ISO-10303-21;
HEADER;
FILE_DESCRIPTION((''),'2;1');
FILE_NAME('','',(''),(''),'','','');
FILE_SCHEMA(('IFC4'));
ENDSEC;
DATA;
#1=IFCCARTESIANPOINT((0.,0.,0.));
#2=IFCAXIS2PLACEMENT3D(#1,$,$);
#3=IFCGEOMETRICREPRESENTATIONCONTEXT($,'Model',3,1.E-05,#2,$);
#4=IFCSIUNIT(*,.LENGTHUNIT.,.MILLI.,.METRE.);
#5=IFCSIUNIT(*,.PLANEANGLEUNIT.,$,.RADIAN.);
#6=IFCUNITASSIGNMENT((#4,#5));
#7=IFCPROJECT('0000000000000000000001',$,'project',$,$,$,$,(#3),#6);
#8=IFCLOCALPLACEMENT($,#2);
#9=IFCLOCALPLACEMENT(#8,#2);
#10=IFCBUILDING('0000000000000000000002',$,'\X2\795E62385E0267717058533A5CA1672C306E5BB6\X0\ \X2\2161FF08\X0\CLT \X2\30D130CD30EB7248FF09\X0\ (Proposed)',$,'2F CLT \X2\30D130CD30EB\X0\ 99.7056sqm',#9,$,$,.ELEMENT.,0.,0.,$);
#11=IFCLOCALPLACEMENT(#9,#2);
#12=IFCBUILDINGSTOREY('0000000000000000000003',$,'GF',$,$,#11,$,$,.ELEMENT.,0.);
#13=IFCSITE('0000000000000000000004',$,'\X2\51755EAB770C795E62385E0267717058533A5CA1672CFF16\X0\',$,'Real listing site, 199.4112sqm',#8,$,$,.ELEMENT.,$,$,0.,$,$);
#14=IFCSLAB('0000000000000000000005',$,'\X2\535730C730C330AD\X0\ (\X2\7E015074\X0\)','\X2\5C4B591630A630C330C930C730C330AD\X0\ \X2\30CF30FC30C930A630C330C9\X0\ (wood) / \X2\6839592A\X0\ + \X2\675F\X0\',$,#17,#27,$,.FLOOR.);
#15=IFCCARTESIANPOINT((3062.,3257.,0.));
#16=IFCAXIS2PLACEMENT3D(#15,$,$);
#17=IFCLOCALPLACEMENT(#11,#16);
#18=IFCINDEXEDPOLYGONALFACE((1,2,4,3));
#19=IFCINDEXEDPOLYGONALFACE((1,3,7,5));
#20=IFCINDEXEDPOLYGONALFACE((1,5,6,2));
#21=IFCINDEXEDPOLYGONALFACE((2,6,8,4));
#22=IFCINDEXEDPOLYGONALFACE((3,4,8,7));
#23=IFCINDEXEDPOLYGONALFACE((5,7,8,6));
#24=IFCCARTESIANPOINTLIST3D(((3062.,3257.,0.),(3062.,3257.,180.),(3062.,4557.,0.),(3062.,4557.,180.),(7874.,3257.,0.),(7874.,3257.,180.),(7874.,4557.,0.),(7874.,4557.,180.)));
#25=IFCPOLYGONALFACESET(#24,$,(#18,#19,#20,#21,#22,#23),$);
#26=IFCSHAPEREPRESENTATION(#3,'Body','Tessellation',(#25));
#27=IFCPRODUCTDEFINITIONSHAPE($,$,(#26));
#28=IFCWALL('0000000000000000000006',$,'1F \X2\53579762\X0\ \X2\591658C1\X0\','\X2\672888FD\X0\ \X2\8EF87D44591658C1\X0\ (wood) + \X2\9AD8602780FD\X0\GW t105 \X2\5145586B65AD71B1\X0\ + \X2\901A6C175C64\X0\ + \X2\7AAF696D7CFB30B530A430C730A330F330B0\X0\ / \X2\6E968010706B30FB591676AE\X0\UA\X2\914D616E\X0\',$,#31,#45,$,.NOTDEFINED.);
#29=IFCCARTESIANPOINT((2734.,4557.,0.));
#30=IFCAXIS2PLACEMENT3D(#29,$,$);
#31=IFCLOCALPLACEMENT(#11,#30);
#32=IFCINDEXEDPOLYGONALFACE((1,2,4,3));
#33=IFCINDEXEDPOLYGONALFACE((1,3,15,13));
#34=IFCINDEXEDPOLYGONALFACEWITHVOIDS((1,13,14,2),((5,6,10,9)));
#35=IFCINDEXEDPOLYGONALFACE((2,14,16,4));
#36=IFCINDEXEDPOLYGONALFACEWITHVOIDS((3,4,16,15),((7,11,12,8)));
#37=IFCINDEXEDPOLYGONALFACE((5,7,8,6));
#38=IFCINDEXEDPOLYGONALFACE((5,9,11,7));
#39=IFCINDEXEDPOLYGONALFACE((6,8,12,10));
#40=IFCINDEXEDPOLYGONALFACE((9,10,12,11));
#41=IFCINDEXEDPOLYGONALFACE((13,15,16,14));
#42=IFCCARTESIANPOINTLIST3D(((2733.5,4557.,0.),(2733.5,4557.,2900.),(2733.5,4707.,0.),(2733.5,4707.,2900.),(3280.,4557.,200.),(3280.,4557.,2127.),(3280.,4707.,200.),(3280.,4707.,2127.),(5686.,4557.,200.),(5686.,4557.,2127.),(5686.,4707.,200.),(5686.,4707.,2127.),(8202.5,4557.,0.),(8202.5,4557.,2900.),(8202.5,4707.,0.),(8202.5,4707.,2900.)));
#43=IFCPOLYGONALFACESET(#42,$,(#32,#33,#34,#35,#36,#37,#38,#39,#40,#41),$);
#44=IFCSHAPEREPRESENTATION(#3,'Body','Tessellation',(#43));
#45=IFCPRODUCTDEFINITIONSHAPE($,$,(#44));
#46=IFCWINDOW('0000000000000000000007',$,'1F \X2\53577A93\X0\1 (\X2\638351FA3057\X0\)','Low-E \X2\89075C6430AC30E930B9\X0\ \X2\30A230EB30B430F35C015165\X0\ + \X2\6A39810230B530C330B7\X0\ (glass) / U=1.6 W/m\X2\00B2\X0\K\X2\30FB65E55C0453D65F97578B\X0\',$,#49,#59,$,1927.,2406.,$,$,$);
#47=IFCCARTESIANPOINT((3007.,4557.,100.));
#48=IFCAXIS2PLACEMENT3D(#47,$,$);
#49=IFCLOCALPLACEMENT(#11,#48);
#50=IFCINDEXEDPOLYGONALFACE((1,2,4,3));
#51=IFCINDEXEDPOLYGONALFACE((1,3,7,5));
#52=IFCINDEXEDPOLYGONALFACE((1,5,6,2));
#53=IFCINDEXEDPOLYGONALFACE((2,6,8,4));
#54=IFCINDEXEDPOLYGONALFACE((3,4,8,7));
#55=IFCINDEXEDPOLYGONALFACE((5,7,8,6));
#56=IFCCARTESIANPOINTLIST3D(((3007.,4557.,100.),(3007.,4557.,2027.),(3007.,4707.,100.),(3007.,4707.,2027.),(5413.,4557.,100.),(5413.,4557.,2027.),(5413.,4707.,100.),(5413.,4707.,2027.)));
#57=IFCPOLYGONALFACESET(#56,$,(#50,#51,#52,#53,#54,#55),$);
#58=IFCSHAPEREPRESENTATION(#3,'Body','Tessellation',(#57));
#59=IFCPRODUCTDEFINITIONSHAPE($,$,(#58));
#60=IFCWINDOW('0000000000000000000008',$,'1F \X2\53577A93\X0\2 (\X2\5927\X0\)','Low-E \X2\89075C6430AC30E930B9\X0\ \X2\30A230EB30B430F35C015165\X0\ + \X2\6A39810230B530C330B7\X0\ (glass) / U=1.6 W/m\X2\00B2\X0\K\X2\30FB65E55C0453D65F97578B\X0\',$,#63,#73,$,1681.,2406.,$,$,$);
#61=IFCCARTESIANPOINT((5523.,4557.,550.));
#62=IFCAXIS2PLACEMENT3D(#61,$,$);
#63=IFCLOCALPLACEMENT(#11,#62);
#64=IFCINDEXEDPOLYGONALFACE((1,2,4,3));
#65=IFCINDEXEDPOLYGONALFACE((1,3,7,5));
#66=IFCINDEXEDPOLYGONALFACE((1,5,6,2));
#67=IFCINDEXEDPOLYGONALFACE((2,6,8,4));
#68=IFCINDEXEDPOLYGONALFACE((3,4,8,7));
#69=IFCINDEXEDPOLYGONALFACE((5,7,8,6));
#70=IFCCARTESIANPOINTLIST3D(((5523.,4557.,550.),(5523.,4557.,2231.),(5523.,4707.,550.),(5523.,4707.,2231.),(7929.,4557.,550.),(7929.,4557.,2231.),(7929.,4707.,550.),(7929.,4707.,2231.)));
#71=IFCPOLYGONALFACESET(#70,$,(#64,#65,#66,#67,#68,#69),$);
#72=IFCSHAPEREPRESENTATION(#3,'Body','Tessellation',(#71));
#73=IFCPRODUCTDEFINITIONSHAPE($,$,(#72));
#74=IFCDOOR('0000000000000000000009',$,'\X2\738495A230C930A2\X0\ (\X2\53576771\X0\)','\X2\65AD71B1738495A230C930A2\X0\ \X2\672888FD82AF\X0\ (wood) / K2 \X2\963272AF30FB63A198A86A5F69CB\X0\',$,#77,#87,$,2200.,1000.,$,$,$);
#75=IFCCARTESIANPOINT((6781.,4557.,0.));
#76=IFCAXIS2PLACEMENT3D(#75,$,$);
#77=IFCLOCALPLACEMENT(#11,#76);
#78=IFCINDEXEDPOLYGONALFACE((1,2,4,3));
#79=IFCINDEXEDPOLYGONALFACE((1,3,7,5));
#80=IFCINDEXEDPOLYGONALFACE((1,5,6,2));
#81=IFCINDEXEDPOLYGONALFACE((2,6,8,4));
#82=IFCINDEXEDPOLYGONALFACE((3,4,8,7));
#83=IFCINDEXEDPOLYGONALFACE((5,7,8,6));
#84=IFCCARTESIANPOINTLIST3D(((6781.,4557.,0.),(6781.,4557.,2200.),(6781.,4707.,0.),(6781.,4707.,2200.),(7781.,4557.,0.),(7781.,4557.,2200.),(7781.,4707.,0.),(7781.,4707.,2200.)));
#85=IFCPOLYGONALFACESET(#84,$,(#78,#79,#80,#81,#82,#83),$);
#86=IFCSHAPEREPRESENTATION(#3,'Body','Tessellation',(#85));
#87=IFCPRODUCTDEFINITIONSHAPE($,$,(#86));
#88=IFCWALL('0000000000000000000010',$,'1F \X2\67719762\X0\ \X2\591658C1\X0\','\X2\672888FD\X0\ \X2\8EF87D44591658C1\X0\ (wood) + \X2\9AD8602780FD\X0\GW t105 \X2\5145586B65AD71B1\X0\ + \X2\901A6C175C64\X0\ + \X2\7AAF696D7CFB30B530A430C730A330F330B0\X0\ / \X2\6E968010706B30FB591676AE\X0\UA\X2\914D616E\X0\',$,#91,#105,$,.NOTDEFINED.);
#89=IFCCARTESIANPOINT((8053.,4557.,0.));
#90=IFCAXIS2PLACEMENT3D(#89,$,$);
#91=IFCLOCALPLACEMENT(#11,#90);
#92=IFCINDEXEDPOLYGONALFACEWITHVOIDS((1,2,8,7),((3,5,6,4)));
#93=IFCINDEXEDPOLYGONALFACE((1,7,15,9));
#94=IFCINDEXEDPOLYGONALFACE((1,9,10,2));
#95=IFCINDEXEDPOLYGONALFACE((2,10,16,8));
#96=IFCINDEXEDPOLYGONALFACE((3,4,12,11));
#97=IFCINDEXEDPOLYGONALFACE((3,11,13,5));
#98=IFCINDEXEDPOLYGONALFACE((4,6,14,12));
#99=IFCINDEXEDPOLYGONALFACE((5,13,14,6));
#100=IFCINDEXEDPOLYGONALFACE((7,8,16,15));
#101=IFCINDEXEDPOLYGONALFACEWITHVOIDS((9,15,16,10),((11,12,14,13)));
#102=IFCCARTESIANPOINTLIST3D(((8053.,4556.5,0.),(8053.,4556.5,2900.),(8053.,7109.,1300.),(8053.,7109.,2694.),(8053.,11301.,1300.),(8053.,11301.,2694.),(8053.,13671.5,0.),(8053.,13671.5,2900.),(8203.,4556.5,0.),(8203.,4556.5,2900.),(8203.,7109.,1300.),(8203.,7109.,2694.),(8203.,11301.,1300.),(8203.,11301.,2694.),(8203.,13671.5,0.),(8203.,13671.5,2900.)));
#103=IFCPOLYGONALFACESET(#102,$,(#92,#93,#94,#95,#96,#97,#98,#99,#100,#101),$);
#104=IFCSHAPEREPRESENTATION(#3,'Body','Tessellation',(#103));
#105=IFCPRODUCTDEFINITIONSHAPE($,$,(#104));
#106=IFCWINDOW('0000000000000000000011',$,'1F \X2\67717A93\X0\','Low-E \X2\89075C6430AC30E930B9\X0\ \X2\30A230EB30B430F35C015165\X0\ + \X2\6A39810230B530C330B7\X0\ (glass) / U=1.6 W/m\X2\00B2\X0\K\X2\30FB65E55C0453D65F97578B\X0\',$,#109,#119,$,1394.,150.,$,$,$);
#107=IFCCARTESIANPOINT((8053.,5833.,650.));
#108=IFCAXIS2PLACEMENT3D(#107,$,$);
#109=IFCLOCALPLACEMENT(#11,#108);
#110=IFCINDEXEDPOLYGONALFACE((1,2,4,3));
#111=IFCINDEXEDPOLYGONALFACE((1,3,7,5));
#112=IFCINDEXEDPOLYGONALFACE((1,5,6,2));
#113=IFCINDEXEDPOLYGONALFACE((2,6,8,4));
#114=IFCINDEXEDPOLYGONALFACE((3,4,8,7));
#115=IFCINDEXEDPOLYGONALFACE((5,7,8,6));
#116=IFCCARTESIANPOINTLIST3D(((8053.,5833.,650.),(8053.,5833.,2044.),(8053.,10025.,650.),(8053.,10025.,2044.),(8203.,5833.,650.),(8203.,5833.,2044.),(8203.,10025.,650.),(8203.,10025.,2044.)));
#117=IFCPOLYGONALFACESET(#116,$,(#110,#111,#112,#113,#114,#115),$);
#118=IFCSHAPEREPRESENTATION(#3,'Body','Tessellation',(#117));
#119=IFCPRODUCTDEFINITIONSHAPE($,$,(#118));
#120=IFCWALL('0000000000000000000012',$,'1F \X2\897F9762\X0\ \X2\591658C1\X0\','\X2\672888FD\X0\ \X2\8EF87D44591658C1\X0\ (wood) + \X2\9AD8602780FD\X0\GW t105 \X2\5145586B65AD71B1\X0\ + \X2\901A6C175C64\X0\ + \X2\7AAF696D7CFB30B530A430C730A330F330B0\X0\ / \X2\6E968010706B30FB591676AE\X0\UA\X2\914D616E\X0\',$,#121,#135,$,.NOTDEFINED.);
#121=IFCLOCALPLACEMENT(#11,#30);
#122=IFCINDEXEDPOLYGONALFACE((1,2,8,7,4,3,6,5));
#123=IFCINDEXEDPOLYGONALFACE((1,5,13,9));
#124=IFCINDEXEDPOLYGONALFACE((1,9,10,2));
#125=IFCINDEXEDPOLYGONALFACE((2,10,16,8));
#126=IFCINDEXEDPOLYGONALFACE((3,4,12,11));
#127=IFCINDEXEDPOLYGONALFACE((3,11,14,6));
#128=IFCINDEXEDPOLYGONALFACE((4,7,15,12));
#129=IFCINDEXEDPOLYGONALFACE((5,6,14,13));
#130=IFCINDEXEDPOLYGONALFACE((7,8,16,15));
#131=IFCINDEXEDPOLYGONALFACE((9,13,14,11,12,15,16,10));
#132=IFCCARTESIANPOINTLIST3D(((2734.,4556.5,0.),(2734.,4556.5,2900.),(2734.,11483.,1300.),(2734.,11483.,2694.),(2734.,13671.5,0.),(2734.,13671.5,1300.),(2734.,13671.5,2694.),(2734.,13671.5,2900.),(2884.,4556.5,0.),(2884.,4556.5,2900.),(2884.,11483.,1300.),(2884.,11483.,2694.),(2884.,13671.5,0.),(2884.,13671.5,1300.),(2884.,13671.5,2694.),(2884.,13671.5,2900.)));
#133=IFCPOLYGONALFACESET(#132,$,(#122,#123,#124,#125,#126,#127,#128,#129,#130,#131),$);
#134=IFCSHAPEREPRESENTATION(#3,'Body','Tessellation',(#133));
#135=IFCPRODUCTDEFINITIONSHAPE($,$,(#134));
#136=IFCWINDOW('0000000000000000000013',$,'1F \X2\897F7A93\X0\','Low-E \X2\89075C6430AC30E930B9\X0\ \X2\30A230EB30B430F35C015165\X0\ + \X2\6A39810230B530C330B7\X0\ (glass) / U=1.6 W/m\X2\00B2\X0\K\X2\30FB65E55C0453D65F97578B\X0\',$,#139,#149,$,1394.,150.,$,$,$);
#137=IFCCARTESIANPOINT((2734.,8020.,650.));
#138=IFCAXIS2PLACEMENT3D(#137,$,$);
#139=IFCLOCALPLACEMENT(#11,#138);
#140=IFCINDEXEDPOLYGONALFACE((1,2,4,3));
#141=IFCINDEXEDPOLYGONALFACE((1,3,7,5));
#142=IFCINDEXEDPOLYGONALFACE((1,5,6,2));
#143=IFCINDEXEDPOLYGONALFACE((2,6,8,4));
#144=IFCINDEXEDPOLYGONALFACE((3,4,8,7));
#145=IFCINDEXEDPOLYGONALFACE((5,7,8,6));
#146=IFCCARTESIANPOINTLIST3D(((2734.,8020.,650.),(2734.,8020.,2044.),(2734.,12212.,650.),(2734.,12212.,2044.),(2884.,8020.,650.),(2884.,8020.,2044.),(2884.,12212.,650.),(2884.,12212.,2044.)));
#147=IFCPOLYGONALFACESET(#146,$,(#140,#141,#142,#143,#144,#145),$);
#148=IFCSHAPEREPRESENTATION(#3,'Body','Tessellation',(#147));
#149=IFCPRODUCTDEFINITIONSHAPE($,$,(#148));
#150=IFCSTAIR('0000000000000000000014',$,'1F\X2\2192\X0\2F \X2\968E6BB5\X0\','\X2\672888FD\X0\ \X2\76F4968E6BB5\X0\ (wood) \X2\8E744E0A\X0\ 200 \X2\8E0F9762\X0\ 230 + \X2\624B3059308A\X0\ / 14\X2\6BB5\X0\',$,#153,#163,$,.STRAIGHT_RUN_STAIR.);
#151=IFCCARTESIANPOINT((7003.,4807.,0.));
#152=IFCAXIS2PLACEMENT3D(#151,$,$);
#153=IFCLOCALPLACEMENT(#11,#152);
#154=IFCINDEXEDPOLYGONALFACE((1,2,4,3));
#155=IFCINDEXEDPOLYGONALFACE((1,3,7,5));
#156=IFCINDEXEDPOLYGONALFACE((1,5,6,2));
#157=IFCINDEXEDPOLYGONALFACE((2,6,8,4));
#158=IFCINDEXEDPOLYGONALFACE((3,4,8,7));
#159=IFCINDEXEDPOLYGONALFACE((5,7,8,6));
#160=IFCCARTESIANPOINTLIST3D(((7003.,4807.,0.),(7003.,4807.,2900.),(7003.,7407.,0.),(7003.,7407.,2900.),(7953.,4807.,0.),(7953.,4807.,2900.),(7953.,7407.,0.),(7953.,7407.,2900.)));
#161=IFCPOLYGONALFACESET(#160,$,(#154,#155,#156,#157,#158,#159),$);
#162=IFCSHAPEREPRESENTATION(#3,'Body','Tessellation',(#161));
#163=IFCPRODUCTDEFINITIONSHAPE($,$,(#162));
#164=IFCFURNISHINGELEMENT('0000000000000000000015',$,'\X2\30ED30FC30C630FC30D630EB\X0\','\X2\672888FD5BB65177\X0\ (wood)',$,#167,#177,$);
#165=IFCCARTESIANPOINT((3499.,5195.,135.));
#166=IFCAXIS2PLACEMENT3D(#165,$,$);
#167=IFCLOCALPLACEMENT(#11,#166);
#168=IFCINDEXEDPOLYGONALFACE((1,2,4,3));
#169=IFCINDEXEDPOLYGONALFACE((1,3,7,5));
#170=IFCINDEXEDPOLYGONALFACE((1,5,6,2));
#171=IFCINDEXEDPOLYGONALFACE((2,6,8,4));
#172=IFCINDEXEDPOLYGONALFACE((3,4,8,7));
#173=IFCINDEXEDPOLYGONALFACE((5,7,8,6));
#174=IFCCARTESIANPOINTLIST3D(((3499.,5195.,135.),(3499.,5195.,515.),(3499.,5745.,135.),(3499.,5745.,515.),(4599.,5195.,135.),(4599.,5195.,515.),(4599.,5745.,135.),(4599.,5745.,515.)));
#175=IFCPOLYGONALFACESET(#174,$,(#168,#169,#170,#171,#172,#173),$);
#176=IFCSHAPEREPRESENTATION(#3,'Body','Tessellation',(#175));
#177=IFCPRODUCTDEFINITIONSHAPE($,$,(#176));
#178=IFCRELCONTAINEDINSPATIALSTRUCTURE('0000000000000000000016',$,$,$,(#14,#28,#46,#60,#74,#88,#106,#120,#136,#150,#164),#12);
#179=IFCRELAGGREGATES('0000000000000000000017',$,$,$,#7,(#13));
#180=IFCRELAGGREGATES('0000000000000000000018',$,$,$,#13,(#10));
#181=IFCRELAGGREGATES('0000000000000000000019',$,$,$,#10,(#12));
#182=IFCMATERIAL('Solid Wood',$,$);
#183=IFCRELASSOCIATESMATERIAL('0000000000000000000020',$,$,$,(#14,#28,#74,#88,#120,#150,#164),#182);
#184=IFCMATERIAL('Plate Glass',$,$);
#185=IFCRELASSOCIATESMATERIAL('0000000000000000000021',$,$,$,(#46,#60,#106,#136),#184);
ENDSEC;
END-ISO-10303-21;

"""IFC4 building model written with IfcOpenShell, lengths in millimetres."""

from ifc_helpers import new_model, si_unit, frame, frame_2d, origin, place, context, project, spatial, rectangle, extrude, material, element, fill, save


model = new_model("IFC4")

# Units and contexts
model_context = context("Model", 3, precision=1e-05, world=origin())
ifc_project = project(units=[si_unit("LENGTHUNIT", "METRE", prefix="MILLI"), si_unit("PLANEANGLEUNIT", "RADIAN")], contexts=[model_context])

# Site, building, storey
site_placement = place(None, origin())
site = spatial("IfcSite", under=ifc_project, at=site_placement, Name="兵庫県神戸市東灘区岡本６", ObjectType="Real listing site, 199.4112sqm", CompositionType="ELEMENT", RefElevation=0.0)
building_placement = place(site_placement, origin())
building = spatial("IfcBuilding", under=site, at=building_placement, Name="神戸市東灘区岡本の家 Ⅱ（CLT パネル版） (Proposed)", ObjectType="2F CLT パネル 99.7056sqm", CompositionType="ELEMENT", ElevationOfRefHeight=0.0, ElevationOfTerrain=0.0)
storey_placement = place(building_placement, origin())
storey = spatial("IfcBuildingStorey", under=building, at=storey_placement, Name="GF", CompositionType="ELEMENT", Elevation=0.0)

# Slab
ifc_material_1 = material(Name="Solid Wood")
slab_1_placement = place(storey_placement, frame((3062.0, 3257.0, 0.0)))
element("IfcSlab", 1, at=slab_1_placement, inside=storey, material=ifc_material_1, Name="南デッキ (縁側)", Description="屋外ウッドデッキ ハードウッド (wood) / 根太 + 束", PredefinedType="FLOOR", context=model_context, shape_type="SweptSolid", body=[
    extrude(rectangle(XDim=4812.0, YDim=1300.0, at=frame_2d((2406.0, 650.0))), frame((3062.0, 3257.0, 0.0)), (0.0, 0.0, 1.0), 180.0),
])

# Wall, openings, windows, door
wall_1_placement = place(storey_placement, frame((2734.0, 4557.0, 0.0)))
wall_1 = element("IfcWall", 2, at=wall_1_placement, inside=storey, material=ifc_material_1, Name="1F 南面 外壁", Description="木製 軸組外壁 (wood) + 高性能GW t105 充填断熱 + 通気層 + 窯業系サイディング / 準耐火・外皮UA配慮", PredefinedType="NOTDEFINED", context=model_context, shape_type="SweptSolid", body=[
    extrude(rectangle(XDim=5469.0, YDim=150.0, at=frame_2d((2734.0, 75.0))), frame((2734.0, 4557.0, 0.0)), (0.0, 0.0, 1.0), 2900.0),
])
opening_1_placement = place(storey_placement, frame((3007.0, 4557.0, 100.0)))
opening_1 = element("IfcOpeningElement", 3, at=opening_1_placement, cuts=wall_1, PredefinedType="NOTDEFINED", context=model_context, shape_type="SweptSolid", body=[
    extrude(rectangle(XDim=2406.0, YDim=150.0, at=frame_2d((1203.0, 75.0))), frame((3007.0, 4557.0, 100.0)), (0.0, 0.0, 1.0), 1927.0),
])
opening_2_placement = place(storey_placement, frame((5523.0, 4557.0, 550.0)))
opening_2 = element("IfcOpeningElement", 4, at=opening_2_placement, cuts=wall_1, PredefinedType="NOTDEFINED", context=model_context, shape_type="SweptSolid", body=[
    extrude(rectangle(XDim=2406.0, YDim=150.0, at=frame_2d((1203.0, 75.0))), frame((5523.0, 4557.0, 550.0)), (0.0, 0.0, 1.0), 1681.0),
])
opening_3_placement = place(storey_placement, frame((6781.0, 4557.0, 0.0)))
opening_3 = element("IfcOpeningElement", 5, at=opening_3_placement, cuts=wall_1, PredefinedType="NOTDEFINED", context=model_context, shape_type="SweptSolid", body=[
    extrude(rectangle(XDim=1000.0, YDim=150.0, at=frame_2d((500.0, 75.0))), frame((6781.0, 4557.0, 0.0)), (0.0, 0.0, 1.0), 2200.0),
])
ifc_material_2 = material(Name="Plate Glass")
window_1_placement = place(storey_placement, frame((3007.0, 4557.0, 100.0)))
window_1 = element("IfcWindow", 6, at=window_1_placement, inside=storey, material=ifc_material_2, Name="1F 南窓1 (掃出し)", Description="Low-E 複層ガラス アルゴン封入 + 樹脂サッシ (glass) / U=1.6 W/m²K・日射取得型", OverallHeight=1927.0, OverallWidth=2406.0, context=model_context, shape_type="SweptSolid", body=[
    extrude(rectangle(XDim=2406.0, YDim=150.0, at=frame_2d((1203.0, 75.0))), frame((3007.0, 4557.0, 100.0)), (0.0, 0.0, 1.0), 1927.0),
])
fill(opening_1, window_1)
window_2_placement = place(storey_placement, frame((5523.0, 4557.0, 550.0)))
window_2 = element("IfcWindow", 7, at=window_2_placement, inside=storey, material=ifc_material_2, Name="1F 南窓2 (大)", Description="Low-E 複層ガラス アルゴン封入 + 樹脂サッシ (glass) / U=1.6 W/m²K・日射取得型", OverallHeight=1681.0, OverallWidth=2406.0, context=model_context, shape_type="SweptSolid", body=[
    extrude(rectangle(XDim=2406.0, YDim=150.0, at=frame_2d((1203.0, 75.0))), frame((5523.0, 4557.0, 550.0)), (0.0, 0.0, 1.0), 1681.0),
])
fill(opening_2, window_2)
door_placement = place(storey_placement, frame((6781.0, 4557.0, 0.0)))
door = element("IfcDoor", 8, at=door_placement, inside=storey, material=ifc_material_1, Name="玄関ドア (南東)", Description="断熱玄関ドア 木製芯 (wood) / K2 防犯・採風機構", OverallHeight=2200.0, OverallWidth=1000.0, context=model_context, shape_type="SweptSolid", body=[
    extrude(rectangle(XDim=1000.0, YDim=150.0, at=frame_2d((500.0, 75.0))), frame((6781.0, 4557.0, 0.0)), (0.0, 0.0, 1.0), 2200.0),
])
fill(opening_3, door)

# Walls, openings, windows
wall_2_placement = place(storey_placement, frame((8053.0, 4557.0, 0.0)))
wall_2 = element("IfcWall", 9, at=wall_2_placement, inside=storey, material=ifc_material_1, Name="1F 東面 外壁", Description="木製 軸組外壁 (wood) + 高性能GW t105 充填断熱 + 通気層 + 窯業系サイディング / 準耐火・外皮UA配慮", PredefinedType="NOTDEFINED", context=model_context, shape_type="SweptSolid", body=[
    extrude(rectangle(XDim=150.0, YDim=9115.0, at=frame_2d((75.0, 4557.0))), frame((8053.0, 4557.0, 0.0)), (0.0, 0.0, 1.0), 2900.0),
])
opening_4_placement = place(storey_placement, frame((8053.0, 5833.0, 650.0)))
opening_4 = element("IfcOpeningElement", 10, at=opening_4_placement, cuts=wall_2, PredefinedType="NOTDEFINED", context=model_context, shape_type="SweptSolid", body=[
    extrude(rectangle(XDim=150.0, YDim=4192.0, at=frame_2d((75.0, 2096.0))), frame((8053.0, 5833.0, 650.0)), (0.0, 0.0, 1.0), 1394.0),
])
window_3_placement = place(storey_placement, frame((8053.0, 5833.0, 650.0)))
window_3 = element("IfcWindow", 11, at=window_3_placement, inside=storey, material=ifc_material_2, Name="1F 東窓", Description="Low-E 複層ガラス アルゴン封入 + 樹脂サッシ (glass) / U=1.6 W/m²K・日射取得型", OverallHeight=1394.0, OverallWidth=150.0, context=model_context, shape_type="SweptSolid", body=[
    extrude(rectangle(XDim=150.0, YDim=4192.0, at=frame_2d((75.0, 2096.0))), frame((8053.0, 5833.0, 650.0)), (0.0, 0.0, 1.0), 1394.0),
])
fill(opening_4, window_3)
wall_3_placement = place(storey_placement, frame((2734.0, 4557.0, 0.0)))
wall_3 = element("IfcWall", 12, at=wall_3_placement, inside=storey, material=ifc_material_1, Name="1F 西面 外壁", Description="木製 軸組外壁 (wood) + 高性能GW t105 充填断熱 + 通気層 + 窯業系サイディング / 準耐火・外皮UA配慮", PredefinedType="NOTDEFINED", context=model_context, shape_type="SweptSolid", body=[
    extrude(rectangle(XDim=150.0, YDim=9115.0, at=frame_2d((75.0, 4557.0))), frame((2734.0, 4557.0, 0.0)), (0.0, 0.0, 1.0), 2900.0),
])
opening_5_placement = place(storey_placement, frame((2734.0, 8020.0, 650.0)))
opening_5 = element("IfcOpeningElement", 13, at=opening_5_placement, cuts=wall_3, PredefinedType="NOTDEFINED", context=model_context, shape_type="SweptSolid", body=[
    extrude(rectangle(XDim=150.0, YDim=4192.0, at=frame_2d((75.0, 2096.0))), frame((2734.0, 8020.0, 650.0)), (0.0, 0.0, 1.0), 1394.0),
])
window_4_placement = place(storey_placement, frame((2734.0, 8020.0, 650.0)))
window_4 = element("IfcWindow", 14, at=window_4_placement, inside=storey, material=ifc_material_2, Name="1F 西窓", Description="Low-E 複層ガラス アルゴン封入 + 樹脂サッシ (glass) / U=1.6 W/m²K・日射取得型", OverallHeight=1394.0, OverallWidth=150.0, context=model_context, shape_type="SweptSolid", body=[
    extrude(rectangle(XDim=150.0, YDim=4192.0, at=frame_2d((75.0, 2096.0))), frame((2734.0, 8020.0, 650.0)), (0.0, 0.0, 1.0), 1394.0),
])
fill(opening_5, window_4)

# Stair
stair_placement = place(storey_placement, frame((7003.0, 4807.0, 0.0)))
element("IfcStair", 15, at=stair_placement, inside=storey, material=ifc_material_1, Name="1F→2F 階段", Description="木製 直階段 (wood) 蹴上 200 踏面 230 + 手すり / 14段", PredefinedType="STRAIGHT_RUN_STAIR", context=model_context, shape_type="SweptSolid", body=[
    extrude(rectangle(XDim=950.0, YDim=2600.0, at=frame_2d((475.0, 1300.0))), frame((7003.0, 4807.0, 0.0)), (0.0, 0.0, 1.0), 2900.0),
])

# Furnishing element
furnishing_1_placement = place(storey_placement, frame((3499.0, 5195.0, 135.0)))
element("IfcFurnishingElement", 16, at=furnishing_1_placement, inside=storey, material=ifc_material_1, Name="ローテーブル", Description="木製家具 (wood)", context=model_context, shape_type="SweptSolid", body=[
    extrude(rectangle(XDim=1100.0, YDim=550.0, at=frame_2d((550.0, 275.0))), frame((3499.0, 5195.0, 135.0)), (0.0, 0.0, 1.0), 380.0),
])

save(model, "model.ifc")
